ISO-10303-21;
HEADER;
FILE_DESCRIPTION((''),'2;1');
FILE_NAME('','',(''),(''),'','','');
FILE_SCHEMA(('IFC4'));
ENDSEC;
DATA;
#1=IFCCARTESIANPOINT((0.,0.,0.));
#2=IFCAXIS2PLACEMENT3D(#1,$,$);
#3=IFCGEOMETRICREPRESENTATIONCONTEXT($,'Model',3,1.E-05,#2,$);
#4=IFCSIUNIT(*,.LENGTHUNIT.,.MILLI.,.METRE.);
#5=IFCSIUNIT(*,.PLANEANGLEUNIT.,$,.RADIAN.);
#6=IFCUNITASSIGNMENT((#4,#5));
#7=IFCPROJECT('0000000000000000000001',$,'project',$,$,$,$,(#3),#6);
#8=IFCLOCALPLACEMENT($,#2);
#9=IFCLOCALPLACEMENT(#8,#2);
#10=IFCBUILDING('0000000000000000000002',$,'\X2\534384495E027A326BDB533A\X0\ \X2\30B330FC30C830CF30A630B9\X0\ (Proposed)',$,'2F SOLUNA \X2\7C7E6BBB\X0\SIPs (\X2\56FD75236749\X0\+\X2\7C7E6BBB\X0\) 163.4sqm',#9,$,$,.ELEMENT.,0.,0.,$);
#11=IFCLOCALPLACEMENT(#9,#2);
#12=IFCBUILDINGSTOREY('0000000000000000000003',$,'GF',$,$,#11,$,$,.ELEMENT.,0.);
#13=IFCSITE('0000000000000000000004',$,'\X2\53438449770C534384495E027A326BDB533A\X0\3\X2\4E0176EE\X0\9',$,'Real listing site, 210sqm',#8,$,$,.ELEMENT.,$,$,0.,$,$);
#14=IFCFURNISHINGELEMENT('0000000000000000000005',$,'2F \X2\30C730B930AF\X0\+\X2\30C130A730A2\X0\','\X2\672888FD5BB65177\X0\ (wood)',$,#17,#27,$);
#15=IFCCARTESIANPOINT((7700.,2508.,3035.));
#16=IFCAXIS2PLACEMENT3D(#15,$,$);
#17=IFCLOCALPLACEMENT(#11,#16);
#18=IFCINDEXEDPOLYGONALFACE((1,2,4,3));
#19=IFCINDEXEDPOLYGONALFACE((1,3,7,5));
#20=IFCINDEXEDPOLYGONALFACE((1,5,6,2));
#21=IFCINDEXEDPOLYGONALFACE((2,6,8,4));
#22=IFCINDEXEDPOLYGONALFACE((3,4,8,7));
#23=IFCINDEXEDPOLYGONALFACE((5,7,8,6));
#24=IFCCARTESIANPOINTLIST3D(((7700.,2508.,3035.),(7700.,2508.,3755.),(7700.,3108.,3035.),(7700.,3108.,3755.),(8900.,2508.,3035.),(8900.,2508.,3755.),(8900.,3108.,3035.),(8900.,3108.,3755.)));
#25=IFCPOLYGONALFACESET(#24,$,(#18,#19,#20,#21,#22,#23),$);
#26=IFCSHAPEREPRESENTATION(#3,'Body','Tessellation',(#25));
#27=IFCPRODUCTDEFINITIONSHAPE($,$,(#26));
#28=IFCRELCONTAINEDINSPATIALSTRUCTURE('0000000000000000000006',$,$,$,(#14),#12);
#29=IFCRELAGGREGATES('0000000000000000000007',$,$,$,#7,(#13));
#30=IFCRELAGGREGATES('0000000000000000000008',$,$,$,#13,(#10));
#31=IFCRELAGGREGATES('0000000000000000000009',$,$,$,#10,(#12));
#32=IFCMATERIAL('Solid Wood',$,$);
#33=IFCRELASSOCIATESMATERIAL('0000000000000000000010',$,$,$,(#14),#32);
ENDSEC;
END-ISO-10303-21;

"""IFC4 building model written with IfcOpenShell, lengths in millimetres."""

from ifc_helpers import new_model, si_unit, frame, frame_2d, origin, place, context, project, spatial, rectangle, extrude, material, element, save


model = new_model("IFC4")

# Units and contexts
model_context = context("Model", 3, precision=1e-05, world=origin())
ifc_project = project(units=[si_unit("LENGTHUNIT", "METRE", prefix="MILLI"), si_unit("PLANEANGLEUNIT", "RADIAN")], contexts=[model_context])

# Site, building, storey
site_placement = place(None, origin())
site = spatial("IfcSite", under=ifc_project, at=site_placement, Name="千葉県千葉市稲毛区3丁目9", ObjectType="Real listing site, 210sqm", CompositionType="ELEMENT", RefElevation=0.0)
building_placement = place(site_placement, origin())
building = spatial("IfcBuilding", under=site, at=building_placement, Name="千葉市稲毛区 コートハウス (Proposed)", ObjectType="2F SOLUNA 籾殻SIPs (国産杉+籾殻) 163.4sqm", CompositionType="ELEMENT", ElevationOfRefHeight=0.0, ElevationOfTerrain=0.0)
storey_placement = place(building_placement, origin())
storey = spatial("IfcBuildingStorey", under=building, at=storey_placement, Name="GF", CompositionType="ELEMENT", Elevation=0.0)

# Shared definitions
ifc_material_1 = material(Name="Solid Wood")

# Furnishing element
furnishing_1_placement = place(storey_placement, frame((7700.0, 2508.0, 3035.0)))
element("IfcFurnishingElement", 1, at=furnishing_1_placement, inside=storey, material=ifc_material_1, Name="2F デスク+チェア", Description="木製家具 (wood)", context=model_context, shape_type="SweptSolid", body=[
    extrude(rectangle(XDim=1200.0, YDim=600.0, at=frame_2d((600.0, 300.0))), frame((7700.0, 2508.0, 3035.0)), (0.0, 0.0, 1.0), 720.0),
])

save(model, "model.ifc")
